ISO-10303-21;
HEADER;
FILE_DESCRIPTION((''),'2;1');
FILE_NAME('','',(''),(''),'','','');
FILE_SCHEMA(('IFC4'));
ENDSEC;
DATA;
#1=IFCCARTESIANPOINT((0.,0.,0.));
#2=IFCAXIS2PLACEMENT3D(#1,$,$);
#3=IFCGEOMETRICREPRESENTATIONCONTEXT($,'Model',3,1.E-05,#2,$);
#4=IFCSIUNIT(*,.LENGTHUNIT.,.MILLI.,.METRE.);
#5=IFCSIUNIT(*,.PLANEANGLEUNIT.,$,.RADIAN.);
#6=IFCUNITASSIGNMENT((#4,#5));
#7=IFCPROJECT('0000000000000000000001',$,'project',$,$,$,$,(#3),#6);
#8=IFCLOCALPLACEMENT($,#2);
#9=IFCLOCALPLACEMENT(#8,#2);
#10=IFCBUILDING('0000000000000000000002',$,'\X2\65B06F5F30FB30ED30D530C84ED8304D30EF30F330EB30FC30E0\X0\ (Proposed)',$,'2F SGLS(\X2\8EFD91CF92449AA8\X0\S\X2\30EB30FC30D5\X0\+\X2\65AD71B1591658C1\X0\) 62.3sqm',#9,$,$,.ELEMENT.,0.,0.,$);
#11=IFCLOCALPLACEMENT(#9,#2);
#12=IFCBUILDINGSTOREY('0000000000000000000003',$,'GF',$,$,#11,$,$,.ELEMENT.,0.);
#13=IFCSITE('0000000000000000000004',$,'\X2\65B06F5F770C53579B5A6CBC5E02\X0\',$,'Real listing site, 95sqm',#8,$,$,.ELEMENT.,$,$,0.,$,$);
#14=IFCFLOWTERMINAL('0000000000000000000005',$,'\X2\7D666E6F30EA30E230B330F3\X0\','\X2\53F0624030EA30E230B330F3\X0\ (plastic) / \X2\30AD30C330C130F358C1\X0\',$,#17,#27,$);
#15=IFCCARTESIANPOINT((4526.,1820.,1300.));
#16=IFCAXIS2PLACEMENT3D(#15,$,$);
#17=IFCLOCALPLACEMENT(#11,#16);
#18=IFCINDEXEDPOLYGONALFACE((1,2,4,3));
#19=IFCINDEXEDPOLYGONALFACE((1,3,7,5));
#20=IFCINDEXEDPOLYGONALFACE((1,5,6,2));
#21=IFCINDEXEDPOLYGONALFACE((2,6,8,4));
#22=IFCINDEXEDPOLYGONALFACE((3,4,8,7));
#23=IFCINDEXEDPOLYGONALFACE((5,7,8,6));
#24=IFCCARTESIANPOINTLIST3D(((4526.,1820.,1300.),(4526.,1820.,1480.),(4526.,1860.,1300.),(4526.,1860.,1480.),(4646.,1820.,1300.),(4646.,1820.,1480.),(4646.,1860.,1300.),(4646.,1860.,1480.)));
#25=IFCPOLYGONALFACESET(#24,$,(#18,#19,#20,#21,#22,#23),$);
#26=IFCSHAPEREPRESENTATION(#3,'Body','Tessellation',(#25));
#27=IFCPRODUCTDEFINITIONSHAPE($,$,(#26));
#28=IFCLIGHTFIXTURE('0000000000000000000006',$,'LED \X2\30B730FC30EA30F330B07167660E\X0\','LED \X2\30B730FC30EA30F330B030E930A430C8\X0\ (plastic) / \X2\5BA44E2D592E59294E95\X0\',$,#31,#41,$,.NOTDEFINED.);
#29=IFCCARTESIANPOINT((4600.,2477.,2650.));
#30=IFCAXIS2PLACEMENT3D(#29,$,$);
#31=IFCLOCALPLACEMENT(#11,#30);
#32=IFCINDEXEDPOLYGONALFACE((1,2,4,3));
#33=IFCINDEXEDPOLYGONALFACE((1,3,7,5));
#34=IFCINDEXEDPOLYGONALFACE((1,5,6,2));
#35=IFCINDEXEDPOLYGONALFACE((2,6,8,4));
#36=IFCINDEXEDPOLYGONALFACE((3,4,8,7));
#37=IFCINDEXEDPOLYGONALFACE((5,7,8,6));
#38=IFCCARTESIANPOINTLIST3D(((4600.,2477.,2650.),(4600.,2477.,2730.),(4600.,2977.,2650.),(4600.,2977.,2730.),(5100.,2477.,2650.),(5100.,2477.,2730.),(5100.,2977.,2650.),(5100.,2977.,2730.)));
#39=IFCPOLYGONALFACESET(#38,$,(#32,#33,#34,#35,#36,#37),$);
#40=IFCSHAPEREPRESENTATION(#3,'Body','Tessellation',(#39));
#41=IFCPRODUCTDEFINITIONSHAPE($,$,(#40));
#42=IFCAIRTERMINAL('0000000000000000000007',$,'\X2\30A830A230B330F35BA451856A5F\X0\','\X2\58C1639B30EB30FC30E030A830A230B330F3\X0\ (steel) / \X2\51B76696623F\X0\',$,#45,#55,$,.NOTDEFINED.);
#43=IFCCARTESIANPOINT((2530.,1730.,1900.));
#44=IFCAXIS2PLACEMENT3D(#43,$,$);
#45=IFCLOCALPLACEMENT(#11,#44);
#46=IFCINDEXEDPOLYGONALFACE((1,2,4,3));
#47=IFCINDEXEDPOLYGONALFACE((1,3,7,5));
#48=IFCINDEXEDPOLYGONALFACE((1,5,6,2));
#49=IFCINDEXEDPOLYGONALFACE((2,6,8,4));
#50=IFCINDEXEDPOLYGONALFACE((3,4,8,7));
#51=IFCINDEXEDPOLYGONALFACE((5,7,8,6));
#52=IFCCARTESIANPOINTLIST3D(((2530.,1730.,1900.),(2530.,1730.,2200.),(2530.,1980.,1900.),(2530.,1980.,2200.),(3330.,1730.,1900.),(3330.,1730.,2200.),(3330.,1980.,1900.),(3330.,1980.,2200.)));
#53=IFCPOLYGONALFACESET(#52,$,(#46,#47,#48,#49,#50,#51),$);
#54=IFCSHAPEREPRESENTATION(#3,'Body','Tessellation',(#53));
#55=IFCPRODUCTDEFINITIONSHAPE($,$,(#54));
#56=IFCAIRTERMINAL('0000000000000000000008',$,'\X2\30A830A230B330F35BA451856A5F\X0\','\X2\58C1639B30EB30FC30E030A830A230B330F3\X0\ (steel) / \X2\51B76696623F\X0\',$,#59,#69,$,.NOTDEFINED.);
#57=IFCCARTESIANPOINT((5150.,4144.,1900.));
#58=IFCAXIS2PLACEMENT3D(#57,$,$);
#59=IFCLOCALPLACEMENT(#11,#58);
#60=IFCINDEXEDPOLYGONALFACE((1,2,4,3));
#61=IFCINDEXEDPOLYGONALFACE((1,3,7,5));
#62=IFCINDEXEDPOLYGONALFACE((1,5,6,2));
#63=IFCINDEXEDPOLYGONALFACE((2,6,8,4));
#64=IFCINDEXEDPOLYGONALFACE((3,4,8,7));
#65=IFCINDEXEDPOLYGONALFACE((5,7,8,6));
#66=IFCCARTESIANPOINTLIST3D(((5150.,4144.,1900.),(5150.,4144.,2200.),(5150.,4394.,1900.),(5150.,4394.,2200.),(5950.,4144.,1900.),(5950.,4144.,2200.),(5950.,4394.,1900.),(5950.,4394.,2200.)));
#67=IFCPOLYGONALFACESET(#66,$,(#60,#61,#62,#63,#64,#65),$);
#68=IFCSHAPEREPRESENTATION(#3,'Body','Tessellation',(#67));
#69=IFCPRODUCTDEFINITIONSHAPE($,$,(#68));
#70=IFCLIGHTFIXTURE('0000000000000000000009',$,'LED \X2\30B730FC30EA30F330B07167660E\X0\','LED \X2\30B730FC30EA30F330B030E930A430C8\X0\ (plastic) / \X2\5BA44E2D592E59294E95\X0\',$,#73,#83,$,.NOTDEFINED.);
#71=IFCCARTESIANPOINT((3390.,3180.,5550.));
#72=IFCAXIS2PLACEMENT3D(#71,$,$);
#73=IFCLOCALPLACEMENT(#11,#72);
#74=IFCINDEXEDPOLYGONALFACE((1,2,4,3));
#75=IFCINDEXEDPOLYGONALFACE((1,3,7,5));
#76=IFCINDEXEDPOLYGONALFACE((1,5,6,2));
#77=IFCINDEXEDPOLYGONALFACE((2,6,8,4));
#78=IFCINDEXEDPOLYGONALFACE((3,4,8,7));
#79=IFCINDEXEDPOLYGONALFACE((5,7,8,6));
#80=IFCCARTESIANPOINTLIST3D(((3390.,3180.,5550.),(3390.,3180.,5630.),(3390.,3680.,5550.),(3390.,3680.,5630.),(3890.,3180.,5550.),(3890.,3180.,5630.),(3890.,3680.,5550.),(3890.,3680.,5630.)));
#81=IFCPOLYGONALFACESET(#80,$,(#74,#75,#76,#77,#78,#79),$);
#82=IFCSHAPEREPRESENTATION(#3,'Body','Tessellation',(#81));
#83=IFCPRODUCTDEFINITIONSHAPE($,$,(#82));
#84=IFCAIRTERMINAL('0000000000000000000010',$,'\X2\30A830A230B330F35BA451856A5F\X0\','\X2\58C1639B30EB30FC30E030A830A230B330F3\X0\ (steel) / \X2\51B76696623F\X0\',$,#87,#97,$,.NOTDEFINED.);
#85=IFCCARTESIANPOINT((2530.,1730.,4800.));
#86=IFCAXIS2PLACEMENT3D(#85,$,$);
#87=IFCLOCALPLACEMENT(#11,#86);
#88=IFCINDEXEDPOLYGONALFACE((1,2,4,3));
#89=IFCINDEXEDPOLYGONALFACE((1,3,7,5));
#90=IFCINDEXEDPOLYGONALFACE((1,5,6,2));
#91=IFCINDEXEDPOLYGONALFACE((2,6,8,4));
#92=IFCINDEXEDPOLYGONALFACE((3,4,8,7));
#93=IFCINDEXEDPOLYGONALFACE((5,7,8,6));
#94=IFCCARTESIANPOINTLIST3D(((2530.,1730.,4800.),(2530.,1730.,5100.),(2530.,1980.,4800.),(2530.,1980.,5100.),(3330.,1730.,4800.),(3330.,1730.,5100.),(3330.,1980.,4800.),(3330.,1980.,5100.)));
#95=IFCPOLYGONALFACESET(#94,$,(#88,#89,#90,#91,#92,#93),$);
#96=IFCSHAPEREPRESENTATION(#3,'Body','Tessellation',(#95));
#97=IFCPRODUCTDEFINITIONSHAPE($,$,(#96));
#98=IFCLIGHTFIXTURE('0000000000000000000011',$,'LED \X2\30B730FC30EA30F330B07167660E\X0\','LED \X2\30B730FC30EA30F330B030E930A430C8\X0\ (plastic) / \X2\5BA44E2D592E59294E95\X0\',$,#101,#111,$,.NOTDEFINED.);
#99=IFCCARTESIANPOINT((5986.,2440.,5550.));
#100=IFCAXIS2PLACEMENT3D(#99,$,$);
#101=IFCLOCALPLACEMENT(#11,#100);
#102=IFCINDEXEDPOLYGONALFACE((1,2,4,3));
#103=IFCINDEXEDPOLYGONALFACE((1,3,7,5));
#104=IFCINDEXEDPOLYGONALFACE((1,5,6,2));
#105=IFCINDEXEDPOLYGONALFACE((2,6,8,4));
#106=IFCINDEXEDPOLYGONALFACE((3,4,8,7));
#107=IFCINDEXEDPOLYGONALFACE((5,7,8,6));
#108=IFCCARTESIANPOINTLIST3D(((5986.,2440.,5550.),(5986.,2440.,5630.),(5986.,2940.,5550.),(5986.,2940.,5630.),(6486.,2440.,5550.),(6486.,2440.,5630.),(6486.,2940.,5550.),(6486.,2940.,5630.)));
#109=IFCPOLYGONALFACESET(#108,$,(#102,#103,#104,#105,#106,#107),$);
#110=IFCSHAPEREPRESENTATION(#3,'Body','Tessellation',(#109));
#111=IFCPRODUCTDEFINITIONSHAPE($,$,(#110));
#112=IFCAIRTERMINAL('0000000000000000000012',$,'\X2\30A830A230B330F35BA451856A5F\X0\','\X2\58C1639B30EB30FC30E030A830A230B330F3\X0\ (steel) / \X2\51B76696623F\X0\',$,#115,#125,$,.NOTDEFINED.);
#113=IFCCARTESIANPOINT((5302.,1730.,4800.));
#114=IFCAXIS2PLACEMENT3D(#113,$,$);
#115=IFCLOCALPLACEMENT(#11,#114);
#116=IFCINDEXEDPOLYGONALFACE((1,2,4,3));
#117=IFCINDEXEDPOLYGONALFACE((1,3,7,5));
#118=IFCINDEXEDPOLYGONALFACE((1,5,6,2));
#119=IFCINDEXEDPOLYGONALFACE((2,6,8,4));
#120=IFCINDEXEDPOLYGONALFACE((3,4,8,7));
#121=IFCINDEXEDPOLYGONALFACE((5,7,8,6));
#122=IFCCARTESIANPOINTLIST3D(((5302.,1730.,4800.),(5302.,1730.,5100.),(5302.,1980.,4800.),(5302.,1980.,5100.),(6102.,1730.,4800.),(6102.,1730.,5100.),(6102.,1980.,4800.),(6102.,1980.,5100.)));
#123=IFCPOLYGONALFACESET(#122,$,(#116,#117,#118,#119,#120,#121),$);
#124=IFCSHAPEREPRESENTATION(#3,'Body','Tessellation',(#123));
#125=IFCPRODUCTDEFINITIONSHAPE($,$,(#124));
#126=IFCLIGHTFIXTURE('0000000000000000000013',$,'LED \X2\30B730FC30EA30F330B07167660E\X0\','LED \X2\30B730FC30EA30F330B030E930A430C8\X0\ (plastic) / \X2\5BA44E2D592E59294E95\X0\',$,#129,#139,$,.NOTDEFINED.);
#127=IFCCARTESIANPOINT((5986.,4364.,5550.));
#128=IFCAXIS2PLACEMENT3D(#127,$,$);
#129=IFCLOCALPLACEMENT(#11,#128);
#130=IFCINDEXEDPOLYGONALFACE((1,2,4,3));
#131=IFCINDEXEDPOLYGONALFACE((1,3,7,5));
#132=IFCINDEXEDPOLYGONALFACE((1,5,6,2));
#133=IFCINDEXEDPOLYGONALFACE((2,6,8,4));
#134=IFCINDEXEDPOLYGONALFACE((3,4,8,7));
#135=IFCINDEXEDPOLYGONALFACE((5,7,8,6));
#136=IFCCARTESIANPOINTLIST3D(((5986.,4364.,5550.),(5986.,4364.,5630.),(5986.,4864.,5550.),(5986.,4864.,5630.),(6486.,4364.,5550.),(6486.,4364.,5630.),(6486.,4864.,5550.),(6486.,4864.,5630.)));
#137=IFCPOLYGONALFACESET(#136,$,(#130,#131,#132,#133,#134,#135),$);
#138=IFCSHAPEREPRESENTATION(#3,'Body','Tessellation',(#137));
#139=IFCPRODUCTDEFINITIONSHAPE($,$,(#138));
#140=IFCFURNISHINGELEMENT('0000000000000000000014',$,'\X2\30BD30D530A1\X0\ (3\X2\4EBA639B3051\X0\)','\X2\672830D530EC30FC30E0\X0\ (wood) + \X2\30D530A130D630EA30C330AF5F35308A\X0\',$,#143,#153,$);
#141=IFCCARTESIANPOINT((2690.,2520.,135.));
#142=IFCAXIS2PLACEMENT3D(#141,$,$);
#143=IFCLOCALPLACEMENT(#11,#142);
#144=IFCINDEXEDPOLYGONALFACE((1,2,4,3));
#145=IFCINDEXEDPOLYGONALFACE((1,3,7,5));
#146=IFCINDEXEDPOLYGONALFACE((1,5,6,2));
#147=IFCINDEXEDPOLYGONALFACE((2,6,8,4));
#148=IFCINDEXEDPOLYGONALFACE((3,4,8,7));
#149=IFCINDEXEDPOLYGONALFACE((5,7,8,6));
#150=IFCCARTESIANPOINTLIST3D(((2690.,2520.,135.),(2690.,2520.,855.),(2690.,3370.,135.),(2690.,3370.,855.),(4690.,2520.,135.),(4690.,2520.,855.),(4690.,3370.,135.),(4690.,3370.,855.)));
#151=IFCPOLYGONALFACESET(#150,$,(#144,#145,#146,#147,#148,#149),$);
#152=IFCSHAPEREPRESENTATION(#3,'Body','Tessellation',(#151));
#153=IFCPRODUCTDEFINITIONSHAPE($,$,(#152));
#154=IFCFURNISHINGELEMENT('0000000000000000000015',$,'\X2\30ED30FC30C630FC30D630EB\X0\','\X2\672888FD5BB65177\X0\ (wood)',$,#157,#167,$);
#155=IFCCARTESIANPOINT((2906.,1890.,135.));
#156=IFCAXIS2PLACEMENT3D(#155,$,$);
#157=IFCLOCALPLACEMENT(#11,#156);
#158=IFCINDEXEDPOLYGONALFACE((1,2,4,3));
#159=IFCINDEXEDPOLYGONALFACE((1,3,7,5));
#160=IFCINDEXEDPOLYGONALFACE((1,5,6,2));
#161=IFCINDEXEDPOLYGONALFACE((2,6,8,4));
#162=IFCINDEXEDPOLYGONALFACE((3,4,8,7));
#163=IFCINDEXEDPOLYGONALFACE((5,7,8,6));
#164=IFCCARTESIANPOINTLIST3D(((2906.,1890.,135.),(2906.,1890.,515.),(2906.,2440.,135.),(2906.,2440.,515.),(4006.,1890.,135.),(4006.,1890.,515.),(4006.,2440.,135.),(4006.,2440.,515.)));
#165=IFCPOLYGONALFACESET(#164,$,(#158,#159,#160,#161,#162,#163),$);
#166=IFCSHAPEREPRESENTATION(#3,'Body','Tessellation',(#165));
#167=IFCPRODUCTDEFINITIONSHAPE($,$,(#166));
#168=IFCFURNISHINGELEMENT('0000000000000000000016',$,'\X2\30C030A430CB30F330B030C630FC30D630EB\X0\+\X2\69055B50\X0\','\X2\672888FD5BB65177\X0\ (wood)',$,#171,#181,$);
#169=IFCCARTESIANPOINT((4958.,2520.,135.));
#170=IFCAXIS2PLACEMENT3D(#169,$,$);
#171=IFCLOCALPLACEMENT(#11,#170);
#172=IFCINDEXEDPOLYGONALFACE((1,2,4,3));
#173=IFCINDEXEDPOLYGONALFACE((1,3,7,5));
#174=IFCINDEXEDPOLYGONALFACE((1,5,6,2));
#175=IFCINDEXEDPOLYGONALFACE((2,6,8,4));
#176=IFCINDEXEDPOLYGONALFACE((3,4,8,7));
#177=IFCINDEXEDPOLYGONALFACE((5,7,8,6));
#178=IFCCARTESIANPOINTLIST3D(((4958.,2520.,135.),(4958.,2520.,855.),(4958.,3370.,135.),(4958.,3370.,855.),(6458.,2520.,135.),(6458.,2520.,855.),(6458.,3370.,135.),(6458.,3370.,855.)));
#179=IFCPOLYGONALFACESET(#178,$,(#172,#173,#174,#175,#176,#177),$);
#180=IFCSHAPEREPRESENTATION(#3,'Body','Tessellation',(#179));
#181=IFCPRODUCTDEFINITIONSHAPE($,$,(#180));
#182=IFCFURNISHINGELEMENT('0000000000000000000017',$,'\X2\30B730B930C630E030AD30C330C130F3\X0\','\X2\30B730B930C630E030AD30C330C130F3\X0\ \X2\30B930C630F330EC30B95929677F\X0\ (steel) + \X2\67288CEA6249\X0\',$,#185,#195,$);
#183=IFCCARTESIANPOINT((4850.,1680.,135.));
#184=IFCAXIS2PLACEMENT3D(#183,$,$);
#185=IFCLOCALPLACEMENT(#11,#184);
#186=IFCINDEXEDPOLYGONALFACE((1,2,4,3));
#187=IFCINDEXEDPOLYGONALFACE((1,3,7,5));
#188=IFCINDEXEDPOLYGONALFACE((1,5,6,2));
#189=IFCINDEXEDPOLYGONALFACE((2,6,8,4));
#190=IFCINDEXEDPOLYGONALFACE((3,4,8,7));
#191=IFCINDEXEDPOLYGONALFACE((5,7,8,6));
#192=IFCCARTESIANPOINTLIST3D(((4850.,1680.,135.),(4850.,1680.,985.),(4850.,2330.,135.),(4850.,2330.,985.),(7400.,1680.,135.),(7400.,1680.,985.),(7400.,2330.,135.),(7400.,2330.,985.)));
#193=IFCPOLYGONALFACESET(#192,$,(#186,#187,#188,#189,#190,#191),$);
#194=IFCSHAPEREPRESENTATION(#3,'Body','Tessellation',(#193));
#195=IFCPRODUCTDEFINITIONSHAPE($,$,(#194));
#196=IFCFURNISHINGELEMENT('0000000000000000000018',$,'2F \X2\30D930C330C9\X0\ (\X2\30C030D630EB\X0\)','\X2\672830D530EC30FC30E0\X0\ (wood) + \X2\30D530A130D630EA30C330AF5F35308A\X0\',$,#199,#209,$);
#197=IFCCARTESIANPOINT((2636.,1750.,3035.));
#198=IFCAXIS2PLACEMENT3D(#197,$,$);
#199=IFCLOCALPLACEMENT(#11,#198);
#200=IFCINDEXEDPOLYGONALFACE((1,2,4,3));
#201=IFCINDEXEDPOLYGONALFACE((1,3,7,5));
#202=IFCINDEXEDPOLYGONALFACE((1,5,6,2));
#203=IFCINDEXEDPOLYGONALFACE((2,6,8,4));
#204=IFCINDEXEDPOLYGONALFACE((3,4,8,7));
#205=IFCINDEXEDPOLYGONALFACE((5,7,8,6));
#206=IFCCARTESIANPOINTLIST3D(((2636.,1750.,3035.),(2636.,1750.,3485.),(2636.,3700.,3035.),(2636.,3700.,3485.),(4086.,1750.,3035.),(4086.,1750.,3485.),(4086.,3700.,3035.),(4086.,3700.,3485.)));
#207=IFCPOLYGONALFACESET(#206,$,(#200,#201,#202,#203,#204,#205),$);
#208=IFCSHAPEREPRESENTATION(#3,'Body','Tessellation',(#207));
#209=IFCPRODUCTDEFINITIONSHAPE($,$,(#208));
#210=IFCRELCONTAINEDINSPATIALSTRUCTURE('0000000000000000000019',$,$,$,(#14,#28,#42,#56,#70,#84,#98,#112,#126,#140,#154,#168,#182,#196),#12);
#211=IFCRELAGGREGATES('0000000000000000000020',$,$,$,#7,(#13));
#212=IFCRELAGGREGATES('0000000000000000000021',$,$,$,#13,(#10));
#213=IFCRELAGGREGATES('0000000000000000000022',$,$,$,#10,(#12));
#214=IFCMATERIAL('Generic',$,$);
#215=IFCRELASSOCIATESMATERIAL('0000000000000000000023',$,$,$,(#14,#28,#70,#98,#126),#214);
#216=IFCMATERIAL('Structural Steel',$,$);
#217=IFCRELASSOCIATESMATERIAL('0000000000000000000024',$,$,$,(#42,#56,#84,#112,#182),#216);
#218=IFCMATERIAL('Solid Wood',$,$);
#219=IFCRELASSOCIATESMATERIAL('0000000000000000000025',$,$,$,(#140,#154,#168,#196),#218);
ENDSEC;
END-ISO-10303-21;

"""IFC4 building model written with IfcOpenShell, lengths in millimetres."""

from ifc_helpers import new_model, si_unit, frame, frame_2d, origin, place, context, project, spatial, rectangle, extrude, material, element, save


model = new_model("IFC4")

# Units and contexts
model_context = context("Model", 3, precision=1e-05, world=origin())
ifc_project = project(units=[si_unit("LENGTHUNIT", "METRE", prefix="MILLI"), si_unit("PLANEANGLEUNIT", "RADIAN")], contexts=[model_context])

# Site, building, storey
site_placement = place(None, origin())
site = spatial("IfcSite", under=ifc_project, at=site_placement, Name="新潟県南魚沼市", ObjectType="Real listing site, 95sqm", CompositionType="ELEMENT", RefElevation=0.0)
building_placement = place(site_placement, origin())
building = spatial("IfcBuilding", under=site, at=building_placement, Name="新潟・ロフト付きワンルーム (Proposed)", ObjectType="2F SGLS(軽量鉄骨Sルーフ+断熱外壁) 62.3sqm", CompositionType="ELEMENT", ElevationOfRefHeight=0.0, ElevationOfTerrain=0.0)
storey_placement = place(building_placement, origin())
storey = spatial("IfcBuildingStorey", under=building, at=storey_placement, Name="GF", CompositionType="ELEMENT", Elevation=0.0)

# Shared definitions
ifc_material_1 = material(Name="Solid Wood")

# Shared definitions
ifc_material_2 = material(Name="Structural Steel")

# Flow terminal
ifc_material_3 = material(Name="Generic")
flow_terminal_1_placement = place(storey_placement, frame((4526.0, 1820.0, 1300.0)))
element("IfcFlowTerminal", 1, at=flow_terminal_1_placement, inside=storey, material=ifc_material_3, Name="給湯リモコン", Description="台所リモコン (plastic) / キッチン壁", context=model_context, shape_type="SweptSolid", body=[
    extrude(rectangle(XDim=120.0, YDim=40.0, at=frame_2d((60.0, 20.0))), frame((4526.0, 1820.0, 1300.0)), (0.0, 0.0, 1.0), 180.0),
])

# Light fixture
light_fixture_1_placement = place(storey_placement, frame((4600.0, 2477.0, 2650.0)))
element("IfcLightFixture", 2, at=light_fixture_1_placement, inside=storey, material=ifc_material_3, Name="LED シーリング照明", Description="LED シーリングライト (plastic) / 室中央天井", PredefinedType="NOTDEFINED", context=model_context, shape_type="SweptSolid", body=[
    extrude(rectangle(XDim=500.0, YDim=500.0, at=frame_2d((250.0, 250.0))), frame((4600.0, 2477.0, 2650.0)), (0.0, 0.0, 1.0), 80.0),
])

# Air terminals
air_terminal_1_placement = place(storey_placement, frame((2530.0, 1730.0, 1900.0)))
element("IfcAirTerminal", 3, at=air_terminal_1_placement, inside=storey, material=ifc_material_2, Name="エアコン室内機", Description="壁掛ルームエアコン (steel) / 冷暖房", PredefinedType="NOTDEFINED", context=model_context, shape_type="SweptSolid", body=[
    extrude(rectangle(XDim=800.0, YDim=250.0, at=frame_2d((400.0, 125.0))), frame((2530.0, 1730.0, 1900.0)), (0.0, 0.0, 1.0), 300.0),
])
air_terminal_2_placement = place(storey_placement, frame((5150.0, 4144.0, 1900.0)))
element("IfcAirTerminal", 4, at=air_terminal_2_placement, inside=storey, material=ifc_material_2, Name="エアコン室内機", Description="壁掛ルームエアコン (steel) / 冷暖房", PredefinedType="NOTDEFINED", context=model_context, shape_type="SweptSolid", body=[
    extrude(rectangle(XDim=800.0, YDim=250.0, at=frame_2d((400.0, 125.0))), frame((5150.0, 4144.0, 1900.0)), (0.0, 0.0, 1.0), 300.0),
])

# Light fixture
light_fixture_2_placement = place(storey_placement, frame((3390.0, 3180.0, 5550.0)))
element("IfcLightFixture", 5, at=light_fixture_2_placement, inside=storey, material=ifc_material_3, Name="LED シーリング照明", Description="LED シーリングライト (plastic) / 室中央天井", PredefinedType="NOTDEFINED", context=model_context, shape_type="SweptSolid", body=[
    extrude(rectangle(XDim=500.0, YDim=500.0, at=frame_2d((250.0, 250.0))), frame((3390.0, 3180.0, 5550.0)), (0.0, 0.0, 1.0), 80.0),
])

# Air terminal
air_terminal_3_placement = place(storey_placement, frame((2530.0, 1730.0, 4800.0)))
element("IfcAirTerminal", 6, at=air_terminal_3_placement, inside=storey, material=ifc_material_2, Name="エアコン室内機", Description="壁掛ルームエアコン (steel) / 冷暖房", PredefinedType="NOTDEFINED", context=model_context, shape_type="SweptSolid", body=[
    extrude(rectangle(XDim=800.0, YDim=250.0, at=frame_2d((400.0, 125.0))), frame((2530.0, 1730.0, 4800.0)), (0.0, 0.0, 1.0), 300.0),
])

# Light fixture
light_fixture_3_placement = place(storey_placement, frame((5986.0, 2440.0, 5550.0)))
element("IfcLightFixture", 7, at=light_fixture_3_placement, inside=storey, material=ifc_material_3, Name="LED シーリング照明", Description="LED シーリングライト (plastic) / 室中央天井", PredefinedType="NOTDEFINED", context=model_context, shape_type="SweptSolid", body=[
    extrude(rectangle(XDim=500.0, YDim=500.0, at=frame_2d((250.0, 250.0))), frame((5986.0, 2440.0, 5550.0)), (0.0, 0.0, 1.0), 80.0),
])

# Air terminal
air_terminal_4_placement = place(storey_placement, frame((5302.0, 1730.0, 4800.0)))
element("IfcAirTerminal", 8, at=air_terminal_4_placement, inside=storey, material=ifc_material_2, Name="エアコン室内機", Description="壁掛ルームエアコン (steel) / 冷暖房", PredefinedType="NOTDEFINED", context=model_context, shape_type="SweptSolid", body=[
    extrude(rectangle(XDim=800.0, YDim=250.0, at=frame_2d((400.0, 125.0))), frame((5302.0, 1730.0, 4800.0)), (0.0, 0.0, 1.0), 300.0),
])

# Light fixture
light_fixture_4_placement = place(storey_placement, frame((5986.0, 4364.0, 5550.0)))
element("IfcLightFixture", 9, at=light_fixture_4_placement, inside=storey, material=ifc_material_3, Name="LED シーリング照明", Description="LED シーリングライト (plastic) / 室中央天井", PredefinedType="NOTDEFINED", context=model_context, shape_type="SweptSolid", body=[
    extrude(rectangle(XDim=500.0, YDim=500.0, at=frame_2d((250.0, 250.0))), frame((5986.0, 4364.0, 5550.0)), (0.0, 0.0, 1.0), 80.0),
])

# Furnishing elements
furnishing_1_placement = place(storey_placement, frame((2690.0, 2520.0, 135.0)))
element("IfcFurnishingElement", 10, at=furnishing_1_placement, inside=storey, material=ifc_material_1, Name="ソファ (3人掛け)", Description="木フレーム (wood) + ファブリック張り", context=model_context, shape_type="SweptSolid", body=[
    extrude(rectangle(XDim=2000.0, YDim=850.0, at=frame_2d((1000.0, 425.0))), frame((2690.0, 2520.0, 135.0)), (0.0, 0.0, 1.0), 720.0),
])
furnishing_2_placement = place(storey_placement, frame((2906.0, 1890.0, 135.0)))
element("IfcFurnishingElement", 11, at=furnishing_2_placement, inside=storey, material=ifc_material_1, Name="ローテーブル", Description="木製家具 (wood)", context=model_context, shape_type="SweptSolid", body=[
    extrude(rectangle(XDim=1100.0, YDim=550.0, at=frame_2d((550.0, 275.0))), frame((2906.0, 1890.0, 135.0)), (0.0, 0.0, 1.0), 380.0),
])
furnishing_3_placement = place(storey_placement, frame((4958.0, 2520.0, 135.0)))
element("IfcFurnishingElement", 12, at=furnishing_3_placement, inside=storey, material=ifc_material_1, Name="ダイニングテーブル+椅子", Description="木製家具 (wood)", context=model_context, shape_type="SweptSolid", body=[
    extrude(rectangle(XDim=1500.0, YDim=850.0, at=frame_2d((750.0, 425.0))), frame((4958.0, 2520.0, 135.0)), (0.0, 0.0, 1.0), 720.0),
])
furnishing_4_placement = place(storey_placement, frame((4850.0, 1680.0, 135.0)))
element("IfcFurnishingElement", 13, at=furnishing_4_placement, inside=storey, material=ifc_material_2, Name="システムキッチン", Description="システムキッチン ステンレス天板 (steel) + 木質扉", context=model_context, shape_type="SweptSolid", body=[
    extrude(rectangle(XDim=2550.0, YDim=650.0, at=frame_2d((1275.0, 325.0))), frame((4850.0, 1680.0, 135.0)), (0.0, 0.0, 1.0), 850.0),
])
furnishing_5_placement = place(storey_placement, frame((2636.0, 1750.0, 3035.0)))
element("IfcFurnishingElement", 14, at=furnishing_5_placement, inside=storey, material=ifc_material_1, Name="2F ベッド (ダブル)", Description="木フレーム (wood) + ファブリック張り", context=model_context, shape_type="SweptSolid", body=[
    extrude(rectangle(XDim=1450.0, YDim=1950.0, at=frame_2d((725.0, 975.0))), frame((2636.0, 1750.0, 3035.0)), (0.0, 0.0, 1.0), 450.0),
])

save(model, "model.ifc")
